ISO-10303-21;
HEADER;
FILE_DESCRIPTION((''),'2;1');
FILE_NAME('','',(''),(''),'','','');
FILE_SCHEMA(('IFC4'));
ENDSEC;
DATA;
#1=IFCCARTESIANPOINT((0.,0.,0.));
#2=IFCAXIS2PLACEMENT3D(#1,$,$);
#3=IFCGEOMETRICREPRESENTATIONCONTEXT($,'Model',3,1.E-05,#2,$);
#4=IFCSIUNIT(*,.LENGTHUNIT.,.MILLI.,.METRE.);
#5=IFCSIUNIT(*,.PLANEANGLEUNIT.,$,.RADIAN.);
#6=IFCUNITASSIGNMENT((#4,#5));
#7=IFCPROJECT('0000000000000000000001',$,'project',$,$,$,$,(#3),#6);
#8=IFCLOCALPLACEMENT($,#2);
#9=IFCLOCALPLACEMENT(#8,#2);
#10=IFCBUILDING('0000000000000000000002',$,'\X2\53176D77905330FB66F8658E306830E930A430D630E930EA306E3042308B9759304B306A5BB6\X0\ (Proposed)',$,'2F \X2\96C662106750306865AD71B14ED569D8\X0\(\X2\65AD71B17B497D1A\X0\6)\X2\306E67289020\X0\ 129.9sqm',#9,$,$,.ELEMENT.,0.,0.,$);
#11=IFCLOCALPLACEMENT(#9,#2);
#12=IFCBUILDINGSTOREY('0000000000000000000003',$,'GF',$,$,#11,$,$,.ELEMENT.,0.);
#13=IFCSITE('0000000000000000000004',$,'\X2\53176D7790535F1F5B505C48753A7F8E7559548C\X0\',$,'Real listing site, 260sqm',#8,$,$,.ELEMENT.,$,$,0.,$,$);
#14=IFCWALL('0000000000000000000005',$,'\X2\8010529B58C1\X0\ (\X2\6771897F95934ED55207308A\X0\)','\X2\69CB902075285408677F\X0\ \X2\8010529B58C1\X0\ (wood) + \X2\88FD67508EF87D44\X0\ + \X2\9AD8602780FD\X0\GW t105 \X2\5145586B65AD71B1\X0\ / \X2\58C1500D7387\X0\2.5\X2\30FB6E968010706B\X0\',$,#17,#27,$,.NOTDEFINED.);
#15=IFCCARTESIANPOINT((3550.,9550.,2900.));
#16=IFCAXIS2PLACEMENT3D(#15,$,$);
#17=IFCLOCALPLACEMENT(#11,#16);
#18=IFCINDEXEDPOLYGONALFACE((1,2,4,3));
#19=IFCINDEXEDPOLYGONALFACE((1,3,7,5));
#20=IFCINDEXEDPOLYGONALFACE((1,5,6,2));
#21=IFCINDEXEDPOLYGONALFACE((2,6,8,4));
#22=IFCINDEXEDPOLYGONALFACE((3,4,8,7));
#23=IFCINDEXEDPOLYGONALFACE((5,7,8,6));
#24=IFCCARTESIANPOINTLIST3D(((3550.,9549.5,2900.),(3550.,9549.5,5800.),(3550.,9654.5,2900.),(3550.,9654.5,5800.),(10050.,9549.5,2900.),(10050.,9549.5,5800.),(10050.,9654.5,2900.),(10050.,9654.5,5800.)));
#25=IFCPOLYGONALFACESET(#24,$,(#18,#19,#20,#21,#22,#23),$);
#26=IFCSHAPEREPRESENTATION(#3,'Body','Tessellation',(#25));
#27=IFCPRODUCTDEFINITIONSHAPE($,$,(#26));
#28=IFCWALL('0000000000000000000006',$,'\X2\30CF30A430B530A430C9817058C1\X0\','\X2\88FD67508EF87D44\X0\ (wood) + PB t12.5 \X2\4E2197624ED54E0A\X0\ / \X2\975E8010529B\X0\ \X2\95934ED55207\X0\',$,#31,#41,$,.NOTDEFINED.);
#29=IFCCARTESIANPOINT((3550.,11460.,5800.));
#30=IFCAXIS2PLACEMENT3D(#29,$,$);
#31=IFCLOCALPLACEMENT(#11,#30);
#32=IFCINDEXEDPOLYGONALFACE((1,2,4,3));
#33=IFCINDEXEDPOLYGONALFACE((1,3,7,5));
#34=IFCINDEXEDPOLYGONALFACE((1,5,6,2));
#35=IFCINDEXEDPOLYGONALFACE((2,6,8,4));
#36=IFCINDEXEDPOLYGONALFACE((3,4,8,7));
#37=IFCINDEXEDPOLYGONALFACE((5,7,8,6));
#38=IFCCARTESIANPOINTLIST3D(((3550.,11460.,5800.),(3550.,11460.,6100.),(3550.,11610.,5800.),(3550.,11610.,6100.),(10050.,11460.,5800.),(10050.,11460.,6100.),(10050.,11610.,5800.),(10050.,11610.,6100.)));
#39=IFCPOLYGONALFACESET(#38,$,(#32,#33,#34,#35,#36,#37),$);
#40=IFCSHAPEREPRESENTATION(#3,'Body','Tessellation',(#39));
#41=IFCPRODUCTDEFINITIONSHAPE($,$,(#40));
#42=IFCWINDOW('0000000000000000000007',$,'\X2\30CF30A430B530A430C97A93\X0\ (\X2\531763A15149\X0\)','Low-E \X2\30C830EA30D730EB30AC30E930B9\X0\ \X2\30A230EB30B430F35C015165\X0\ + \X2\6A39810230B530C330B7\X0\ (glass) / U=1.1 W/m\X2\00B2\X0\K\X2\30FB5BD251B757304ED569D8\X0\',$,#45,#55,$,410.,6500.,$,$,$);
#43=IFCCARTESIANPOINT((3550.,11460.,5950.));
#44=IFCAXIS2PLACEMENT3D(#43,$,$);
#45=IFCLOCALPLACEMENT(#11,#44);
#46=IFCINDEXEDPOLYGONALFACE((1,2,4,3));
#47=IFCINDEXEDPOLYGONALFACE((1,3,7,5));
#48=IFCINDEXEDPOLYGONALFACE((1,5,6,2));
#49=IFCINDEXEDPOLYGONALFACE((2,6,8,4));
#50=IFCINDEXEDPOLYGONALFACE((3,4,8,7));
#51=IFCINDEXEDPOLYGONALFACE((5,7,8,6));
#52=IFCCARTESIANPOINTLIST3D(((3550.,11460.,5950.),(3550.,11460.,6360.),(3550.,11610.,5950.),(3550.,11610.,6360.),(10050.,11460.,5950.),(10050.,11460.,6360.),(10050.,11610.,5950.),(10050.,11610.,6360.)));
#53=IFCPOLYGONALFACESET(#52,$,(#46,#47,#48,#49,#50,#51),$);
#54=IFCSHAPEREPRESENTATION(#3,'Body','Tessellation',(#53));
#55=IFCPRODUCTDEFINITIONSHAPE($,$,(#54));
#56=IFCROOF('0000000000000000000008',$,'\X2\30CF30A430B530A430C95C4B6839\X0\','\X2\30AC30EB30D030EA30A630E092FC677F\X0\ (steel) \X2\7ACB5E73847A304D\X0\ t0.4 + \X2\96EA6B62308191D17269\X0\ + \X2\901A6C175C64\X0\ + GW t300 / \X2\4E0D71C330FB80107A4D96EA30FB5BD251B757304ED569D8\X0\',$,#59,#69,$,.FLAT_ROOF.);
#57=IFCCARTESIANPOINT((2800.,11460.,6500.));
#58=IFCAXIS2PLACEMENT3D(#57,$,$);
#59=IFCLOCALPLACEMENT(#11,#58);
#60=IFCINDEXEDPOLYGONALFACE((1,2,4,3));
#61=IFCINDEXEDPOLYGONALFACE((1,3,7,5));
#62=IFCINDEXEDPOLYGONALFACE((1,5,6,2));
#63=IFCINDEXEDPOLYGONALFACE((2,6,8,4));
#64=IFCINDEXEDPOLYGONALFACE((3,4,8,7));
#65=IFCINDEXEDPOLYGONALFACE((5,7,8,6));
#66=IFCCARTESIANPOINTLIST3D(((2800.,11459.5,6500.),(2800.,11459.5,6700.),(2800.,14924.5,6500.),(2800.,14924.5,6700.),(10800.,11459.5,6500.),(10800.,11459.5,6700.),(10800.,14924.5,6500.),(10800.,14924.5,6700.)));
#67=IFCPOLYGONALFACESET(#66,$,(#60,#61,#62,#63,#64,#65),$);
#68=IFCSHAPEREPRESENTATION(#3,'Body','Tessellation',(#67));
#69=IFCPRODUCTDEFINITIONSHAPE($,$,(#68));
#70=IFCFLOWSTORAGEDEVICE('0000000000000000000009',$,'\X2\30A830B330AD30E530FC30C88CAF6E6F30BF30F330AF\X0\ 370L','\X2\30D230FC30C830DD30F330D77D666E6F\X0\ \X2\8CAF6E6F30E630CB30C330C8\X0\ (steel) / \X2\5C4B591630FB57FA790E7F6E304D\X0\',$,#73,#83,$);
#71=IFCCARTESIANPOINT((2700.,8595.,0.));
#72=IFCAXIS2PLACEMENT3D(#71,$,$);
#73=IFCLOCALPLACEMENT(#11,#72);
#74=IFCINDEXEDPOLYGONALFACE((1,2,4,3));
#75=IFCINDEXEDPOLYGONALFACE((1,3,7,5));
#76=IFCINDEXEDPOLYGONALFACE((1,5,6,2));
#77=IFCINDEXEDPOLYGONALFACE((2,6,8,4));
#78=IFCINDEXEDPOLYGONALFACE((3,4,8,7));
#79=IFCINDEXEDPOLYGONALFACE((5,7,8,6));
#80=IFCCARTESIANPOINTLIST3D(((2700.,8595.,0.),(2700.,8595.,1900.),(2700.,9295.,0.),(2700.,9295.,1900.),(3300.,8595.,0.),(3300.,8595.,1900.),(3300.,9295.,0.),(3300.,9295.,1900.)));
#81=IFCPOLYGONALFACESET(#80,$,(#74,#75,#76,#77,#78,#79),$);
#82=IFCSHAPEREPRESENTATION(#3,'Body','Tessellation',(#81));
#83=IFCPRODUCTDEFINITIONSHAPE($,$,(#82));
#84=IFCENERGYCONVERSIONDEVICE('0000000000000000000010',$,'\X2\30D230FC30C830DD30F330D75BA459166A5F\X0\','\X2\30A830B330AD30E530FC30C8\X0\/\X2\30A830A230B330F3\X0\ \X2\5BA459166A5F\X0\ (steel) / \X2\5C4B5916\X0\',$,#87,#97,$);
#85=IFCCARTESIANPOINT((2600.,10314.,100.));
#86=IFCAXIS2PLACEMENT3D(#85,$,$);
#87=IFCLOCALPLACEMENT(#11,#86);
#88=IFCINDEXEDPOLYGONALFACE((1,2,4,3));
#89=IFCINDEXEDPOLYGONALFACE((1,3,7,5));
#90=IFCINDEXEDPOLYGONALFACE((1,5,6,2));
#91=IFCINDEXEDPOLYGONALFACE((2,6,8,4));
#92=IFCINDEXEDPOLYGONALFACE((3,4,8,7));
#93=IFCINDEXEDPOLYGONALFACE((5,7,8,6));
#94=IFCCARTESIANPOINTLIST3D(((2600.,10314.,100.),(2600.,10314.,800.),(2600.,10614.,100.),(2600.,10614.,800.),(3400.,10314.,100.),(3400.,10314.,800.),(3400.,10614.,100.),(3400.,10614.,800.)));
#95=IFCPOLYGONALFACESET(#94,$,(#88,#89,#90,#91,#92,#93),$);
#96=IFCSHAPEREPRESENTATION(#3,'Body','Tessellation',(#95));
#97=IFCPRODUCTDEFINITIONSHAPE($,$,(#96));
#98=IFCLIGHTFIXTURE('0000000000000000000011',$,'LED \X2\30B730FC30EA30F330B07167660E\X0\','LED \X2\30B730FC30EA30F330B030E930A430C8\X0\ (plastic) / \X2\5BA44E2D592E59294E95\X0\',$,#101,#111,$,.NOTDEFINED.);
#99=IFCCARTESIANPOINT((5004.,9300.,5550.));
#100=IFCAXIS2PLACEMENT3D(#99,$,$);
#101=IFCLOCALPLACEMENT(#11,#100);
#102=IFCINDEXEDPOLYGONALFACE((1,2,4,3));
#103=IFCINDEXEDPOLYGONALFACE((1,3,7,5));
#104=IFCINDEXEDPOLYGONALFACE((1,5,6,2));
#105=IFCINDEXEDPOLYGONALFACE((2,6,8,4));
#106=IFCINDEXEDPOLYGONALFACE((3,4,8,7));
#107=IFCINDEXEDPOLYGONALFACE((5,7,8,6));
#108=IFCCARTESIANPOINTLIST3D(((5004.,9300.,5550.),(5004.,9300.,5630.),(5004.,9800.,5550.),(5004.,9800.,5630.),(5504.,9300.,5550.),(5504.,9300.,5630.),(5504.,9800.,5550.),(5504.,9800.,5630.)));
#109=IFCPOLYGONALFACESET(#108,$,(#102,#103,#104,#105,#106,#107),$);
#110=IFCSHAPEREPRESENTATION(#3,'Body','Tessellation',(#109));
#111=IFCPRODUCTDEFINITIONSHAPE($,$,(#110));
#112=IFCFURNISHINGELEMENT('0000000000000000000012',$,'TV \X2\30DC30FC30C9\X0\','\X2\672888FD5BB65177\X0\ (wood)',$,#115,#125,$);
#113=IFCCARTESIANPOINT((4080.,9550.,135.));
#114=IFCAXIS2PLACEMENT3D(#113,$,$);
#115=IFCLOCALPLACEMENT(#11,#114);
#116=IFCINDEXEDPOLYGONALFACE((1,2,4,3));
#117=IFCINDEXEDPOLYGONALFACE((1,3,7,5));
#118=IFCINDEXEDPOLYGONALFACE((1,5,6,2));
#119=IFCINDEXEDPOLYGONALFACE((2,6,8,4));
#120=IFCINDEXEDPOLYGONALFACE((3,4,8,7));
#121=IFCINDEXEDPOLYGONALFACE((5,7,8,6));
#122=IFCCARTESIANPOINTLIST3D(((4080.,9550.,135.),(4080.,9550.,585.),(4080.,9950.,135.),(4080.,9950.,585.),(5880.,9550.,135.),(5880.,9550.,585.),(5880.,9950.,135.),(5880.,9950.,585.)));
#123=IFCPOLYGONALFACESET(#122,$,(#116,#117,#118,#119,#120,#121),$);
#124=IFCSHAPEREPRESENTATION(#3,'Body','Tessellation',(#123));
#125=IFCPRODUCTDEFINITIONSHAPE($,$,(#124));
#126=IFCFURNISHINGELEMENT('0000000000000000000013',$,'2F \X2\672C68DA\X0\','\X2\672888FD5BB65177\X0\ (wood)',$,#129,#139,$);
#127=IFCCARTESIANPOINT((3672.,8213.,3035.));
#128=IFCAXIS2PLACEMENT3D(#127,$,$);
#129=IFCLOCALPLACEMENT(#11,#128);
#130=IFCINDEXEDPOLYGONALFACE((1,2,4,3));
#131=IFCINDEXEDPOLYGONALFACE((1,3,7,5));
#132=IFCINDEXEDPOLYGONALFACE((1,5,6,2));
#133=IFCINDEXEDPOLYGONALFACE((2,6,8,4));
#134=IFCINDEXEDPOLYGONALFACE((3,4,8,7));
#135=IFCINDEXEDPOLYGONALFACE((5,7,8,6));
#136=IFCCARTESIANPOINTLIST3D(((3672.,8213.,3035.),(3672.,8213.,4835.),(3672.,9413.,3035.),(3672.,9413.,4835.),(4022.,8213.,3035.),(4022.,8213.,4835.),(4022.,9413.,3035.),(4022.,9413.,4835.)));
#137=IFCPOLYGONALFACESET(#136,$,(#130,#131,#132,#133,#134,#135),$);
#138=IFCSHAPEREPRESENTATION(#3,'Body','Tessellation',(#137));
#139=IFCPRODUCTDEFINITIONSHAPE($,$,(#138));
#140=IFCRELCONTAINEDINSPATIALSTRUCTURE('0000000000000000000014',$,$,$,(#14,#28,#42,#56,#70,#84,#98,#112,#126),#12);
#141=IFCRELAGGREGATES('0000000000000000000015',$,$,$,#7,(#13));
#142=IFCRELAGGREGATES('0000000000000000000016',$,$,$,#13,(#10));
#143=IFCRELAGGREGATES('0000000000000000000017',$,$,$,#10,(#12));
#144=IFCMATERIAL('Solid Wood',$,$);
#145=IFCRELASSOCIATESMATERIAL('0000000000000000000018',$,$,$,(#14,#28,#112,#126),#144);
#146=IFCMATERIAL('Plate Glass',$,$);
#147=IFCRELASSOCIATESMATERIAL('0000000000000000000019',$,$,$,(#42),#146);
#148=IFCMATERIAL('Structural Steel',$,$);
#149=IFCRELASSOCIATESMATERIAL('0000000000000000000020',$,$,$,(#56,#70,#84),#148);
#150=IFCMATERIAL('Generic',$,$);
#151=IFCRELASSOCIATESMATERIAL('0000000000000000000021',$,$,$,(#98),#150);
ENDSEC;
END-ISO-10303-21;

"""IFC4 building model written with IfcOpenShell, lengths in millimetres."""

from ifc_helpers import new_model, si_unit, frame, frame_2d, origin, place, context, project, spatial, rectangle, extrude, material, element, fill, save


model = new_model("IFC4")

# Units and contexts
model_context = context("Model", 3, precision=1e-05, world=origin())
ifc_project = project(units=[si_unit("LENGTHUNIT", "METRE", prefix="MILLI"), si_unit("PLANEANGLEUNIT", "RADIAN")], contexts=[model_context])

# Site, building, storey
site_placement = place(None, origin())
site = spatial("IfcSite", under=ifc_project, at=site_placement, Name="北海道弟子屈町美留和", ObjectType="Real listing site, 260sqm", CompositionType="ELEMENT", RefElevation=0.0)
building_placement = place(site_placement, origin())
building = spatial("IfcBuilding", under=site, at=building_placement, Name="北海道・書斎とライブラリのある静かな家 (Proposed)", ObjectType="2F 集成材と断熱仕様(断熱等級6)の木造 129.9sqm", CompositionType="ELEMENT", ElevationOfRefHeight=0.0, ElevationOfTerrain=0.0)
storey_placement = place(building_placement, origin())
storey = spatial("IfcBuildingStorey", under=building, at=storey_placement, Name="GF", CompositionType="ELEMENT", Elevation=0.0)

# Shared definitions
ifc_material_1 = material(Name="Solid Wood")

# Wall
wall_1_placement = place(storey_placement, frame((3550.0, 9550.0, 2900.0)))
element("IfcWall", 1, at=wall_1_placement, inside=storey, material=ifc_material_1, Name="耐力壁 (東西間仕切り)", Description="構造用合板 耐力壁 (wood) + 製材軸組 + 高性能GW t105 充填断熱 / 壁倍率2.5・準耐火", PredefinedType="NOTDEFINED", context=model_context, shape_type="SweptSolid", body=[
    extrude(rectangle(XDim=6500.0, YDim=105.0, at=frame_2d((3250.0, 52.0))), frame((3550.0, 9550.0, 2900.0)), (0.0, 0.0, 1.0), 2900.0),
])

# Wall, opening, window
wall_2_placement = place(storey_placement, frame((3550.0, 11460.0, 5800.0)))
wall_2 = element("IfcWall", 2, at=wall_2_placement, inside=storey, material=ifc_material_1, Name="ハイサイド腰壁", Description="製材軸組 (wood) + PB t12.5 両面仕上 / 非耐力 間仕切", PredefinedType="NOTDEFINED", context=model_context, shape_type="SweptSolid", body=[
    extrude(rectangle(XDim=6500.0, YDim=150.0, at=frame_2d((3250.0, 75.0))), frame((3550.0, 11460.0, 5800.0)), (0.0, 0.0, 1.0), 700.0),
])
opening_1_placement = place(storey_placement, frame((3550.0, 11460.0, 5950.0)))
opening_1 = element("IfcOpeningElement", 3, at=opening_1_placement, cuts=wall_2, PredefinedType="NOTDEFINED", context=model_context, shape_type="SweptSolid", body=[
    extrude(rectangle(XDim=6500.0, YDim=150.0, at=frame_2d((3250.0, 75.0))), frame((3550.0, 11460.0, 5950.0)), (0.0, 0.0, 1.0), 410.0),
])
ifc_material_2 = material(Name="Plate Glass")
window_placement = place(storey_placement, frame((3550.0, 11460.0, 5950.0)))
window = element("IfcWindow", 4, at=window_placement, inside=storey, material=ifc_material_2, Name="ハイサイド窓 (北採光)", Description="Low-E トリプルガラス アルゴン封入 + 樹脂サッシ (glass) / U=1.1 W/m²K・寒冷地仕様", OverallHeight=410.0, OverallWidth=6500.0, context=model_context, shape_type="SweptSolid", body=[
    extrude(rectangle(XDim=6500.0, YDim=150.0, at=frame_2d((3250.0, 75.0))), frame((3550.0, 11460.0, 5950.0)), (0.0, 0.0, 1.0), 410.0),
])
fill(opening_1, window)

# Roof
ifc_material_3 = material(Name="Structural Steel")
roof_placement = place(storey_placement, frame((2800.0, 11460.0, 6500.0)))
element("IfcRoof", 5, at=roof_placement, inside=storey, material=ifc_material_3, Name="ハイサイド屋根", Description="ガルバリウム鋼板 (steel) 立平葺き t0.4 + 雪止め金物 + 通気層 + GW t300 / 不燃・耐積雪・寒冷地仕様", PredefinedType="FLAT_ROOF", context=model_context, shape_type="SweptSolid", body=[
    extrude(rectangle(XDim=8000.0, YDim=3465.0, at=frame_2d((4000.0, 1732.0))), frame((2800.0, 11460.0, 6500.0)), (0.0, 0.0, 1.0), 200.0),
])

# Flow storage device
flow_storage_device_placement = place(storey_placement, frame((2700.0, 8595.0, 0.0)))
element("IfcFlowStorageDevice", 6, at=flow_storage_device_placement, inside=storey, material=ifc_material_3, Name="エコキュート貯湯タンク 370L", Description="ヒートポンプ給湯 貯湯ユニット (steel) / 屋外・基礎置き", context=model_context, shape_type="SweptSolid", body=[
    extrude(rectangle(XDim=600.0, YDim=700.0, at=frame_2d((300.0, 350.0))), frame((2700.0, 8595.0, 0.0)), (0.0, 0.0, 1.0), 1900.0),
])

# Energy conversion device
energy_conversion_device_placement = place(storey_placement, frame((2600.0, 10314.0, 100.0)))
element("IfcEnergyConversionDevice", 7, at=energy_conversion_device_placement, inside=storey, material=ifc_material_3, Name="ヒートポンプ室外機", Description="エコキュート/エアコン 室外機 (steel) / 屋外", context=model_context, shape_type="SweptSolid", body=[
    extrude(rectangle(XDim=800.0, YDim=300.0, at=frame_2d((400.0, 150.0))), frame((2600.0, 10314.0, 100.0)), (0.0, 0.0, 1.0), 700.0),
])

# Light fixture
ifc_material_4 = material(Name="Generic")
light_fixture_placement = place(storey_placement, frame((5004.0, 9300.0, 5550.0)))
element("IfcLightFixture", 8, at=light_fixture_placement, inside=storey, material=ifc_material_4, Name="LED シーリング照明", Description="LED シーリングライト (plastic) / 室中央天井", PredefinedType="NOTDEFINED", context=model_context, shape_type="SweptSolid", body=[
    extrude(rectangle(XDim=500.0, YDim=500.0, at=frame_2d((250.0, 250.0))), frame((5004.0, 9300.0, 5550.0)), (0.0, 0.0, 1.0), 80.0),
])

# Furnishing elements
furnishing_1_placement = place(storey_placement, frame((4080.0, 9550.0, 135.0)))
element("IfcFurnishingElement", 9, at=furnishing_1_placement, inside=storey, material=ifc_material_1, Name="TV ボード", Description="木製家具 (wood)", context=model_context, shape_type="SweptSolid", body=[
    extrude(rectangle(XDim=1800.0, YDim=400.0, at=frame_2d((900.0, 200.0))), frame((4080.0, 9550.0, 135.0)), (0.0, 0.0, 1.0), 450.0),
])
furnishing_2_placement = place(storey_placement, frame((3672.0, 8213.0, 3035.0)))
element("IfcFurnishingElement", 10, at=furnishing_2_placement, inside=storey, material=ifc_material_1, Name="2F 本棚", Description="木製家具 (wood)", context=model_context, shape_type="SweptSolid", body=[
    extrude(rectangle(XDim=350.0, YDim=1200.0, at=frame_2d((175.0, 600.0))), frame((3672.0, 8213.0, 3035.0)), (0.0, 0.0, 1.0), 1800.0),
])

save(model, "model.ifc")
